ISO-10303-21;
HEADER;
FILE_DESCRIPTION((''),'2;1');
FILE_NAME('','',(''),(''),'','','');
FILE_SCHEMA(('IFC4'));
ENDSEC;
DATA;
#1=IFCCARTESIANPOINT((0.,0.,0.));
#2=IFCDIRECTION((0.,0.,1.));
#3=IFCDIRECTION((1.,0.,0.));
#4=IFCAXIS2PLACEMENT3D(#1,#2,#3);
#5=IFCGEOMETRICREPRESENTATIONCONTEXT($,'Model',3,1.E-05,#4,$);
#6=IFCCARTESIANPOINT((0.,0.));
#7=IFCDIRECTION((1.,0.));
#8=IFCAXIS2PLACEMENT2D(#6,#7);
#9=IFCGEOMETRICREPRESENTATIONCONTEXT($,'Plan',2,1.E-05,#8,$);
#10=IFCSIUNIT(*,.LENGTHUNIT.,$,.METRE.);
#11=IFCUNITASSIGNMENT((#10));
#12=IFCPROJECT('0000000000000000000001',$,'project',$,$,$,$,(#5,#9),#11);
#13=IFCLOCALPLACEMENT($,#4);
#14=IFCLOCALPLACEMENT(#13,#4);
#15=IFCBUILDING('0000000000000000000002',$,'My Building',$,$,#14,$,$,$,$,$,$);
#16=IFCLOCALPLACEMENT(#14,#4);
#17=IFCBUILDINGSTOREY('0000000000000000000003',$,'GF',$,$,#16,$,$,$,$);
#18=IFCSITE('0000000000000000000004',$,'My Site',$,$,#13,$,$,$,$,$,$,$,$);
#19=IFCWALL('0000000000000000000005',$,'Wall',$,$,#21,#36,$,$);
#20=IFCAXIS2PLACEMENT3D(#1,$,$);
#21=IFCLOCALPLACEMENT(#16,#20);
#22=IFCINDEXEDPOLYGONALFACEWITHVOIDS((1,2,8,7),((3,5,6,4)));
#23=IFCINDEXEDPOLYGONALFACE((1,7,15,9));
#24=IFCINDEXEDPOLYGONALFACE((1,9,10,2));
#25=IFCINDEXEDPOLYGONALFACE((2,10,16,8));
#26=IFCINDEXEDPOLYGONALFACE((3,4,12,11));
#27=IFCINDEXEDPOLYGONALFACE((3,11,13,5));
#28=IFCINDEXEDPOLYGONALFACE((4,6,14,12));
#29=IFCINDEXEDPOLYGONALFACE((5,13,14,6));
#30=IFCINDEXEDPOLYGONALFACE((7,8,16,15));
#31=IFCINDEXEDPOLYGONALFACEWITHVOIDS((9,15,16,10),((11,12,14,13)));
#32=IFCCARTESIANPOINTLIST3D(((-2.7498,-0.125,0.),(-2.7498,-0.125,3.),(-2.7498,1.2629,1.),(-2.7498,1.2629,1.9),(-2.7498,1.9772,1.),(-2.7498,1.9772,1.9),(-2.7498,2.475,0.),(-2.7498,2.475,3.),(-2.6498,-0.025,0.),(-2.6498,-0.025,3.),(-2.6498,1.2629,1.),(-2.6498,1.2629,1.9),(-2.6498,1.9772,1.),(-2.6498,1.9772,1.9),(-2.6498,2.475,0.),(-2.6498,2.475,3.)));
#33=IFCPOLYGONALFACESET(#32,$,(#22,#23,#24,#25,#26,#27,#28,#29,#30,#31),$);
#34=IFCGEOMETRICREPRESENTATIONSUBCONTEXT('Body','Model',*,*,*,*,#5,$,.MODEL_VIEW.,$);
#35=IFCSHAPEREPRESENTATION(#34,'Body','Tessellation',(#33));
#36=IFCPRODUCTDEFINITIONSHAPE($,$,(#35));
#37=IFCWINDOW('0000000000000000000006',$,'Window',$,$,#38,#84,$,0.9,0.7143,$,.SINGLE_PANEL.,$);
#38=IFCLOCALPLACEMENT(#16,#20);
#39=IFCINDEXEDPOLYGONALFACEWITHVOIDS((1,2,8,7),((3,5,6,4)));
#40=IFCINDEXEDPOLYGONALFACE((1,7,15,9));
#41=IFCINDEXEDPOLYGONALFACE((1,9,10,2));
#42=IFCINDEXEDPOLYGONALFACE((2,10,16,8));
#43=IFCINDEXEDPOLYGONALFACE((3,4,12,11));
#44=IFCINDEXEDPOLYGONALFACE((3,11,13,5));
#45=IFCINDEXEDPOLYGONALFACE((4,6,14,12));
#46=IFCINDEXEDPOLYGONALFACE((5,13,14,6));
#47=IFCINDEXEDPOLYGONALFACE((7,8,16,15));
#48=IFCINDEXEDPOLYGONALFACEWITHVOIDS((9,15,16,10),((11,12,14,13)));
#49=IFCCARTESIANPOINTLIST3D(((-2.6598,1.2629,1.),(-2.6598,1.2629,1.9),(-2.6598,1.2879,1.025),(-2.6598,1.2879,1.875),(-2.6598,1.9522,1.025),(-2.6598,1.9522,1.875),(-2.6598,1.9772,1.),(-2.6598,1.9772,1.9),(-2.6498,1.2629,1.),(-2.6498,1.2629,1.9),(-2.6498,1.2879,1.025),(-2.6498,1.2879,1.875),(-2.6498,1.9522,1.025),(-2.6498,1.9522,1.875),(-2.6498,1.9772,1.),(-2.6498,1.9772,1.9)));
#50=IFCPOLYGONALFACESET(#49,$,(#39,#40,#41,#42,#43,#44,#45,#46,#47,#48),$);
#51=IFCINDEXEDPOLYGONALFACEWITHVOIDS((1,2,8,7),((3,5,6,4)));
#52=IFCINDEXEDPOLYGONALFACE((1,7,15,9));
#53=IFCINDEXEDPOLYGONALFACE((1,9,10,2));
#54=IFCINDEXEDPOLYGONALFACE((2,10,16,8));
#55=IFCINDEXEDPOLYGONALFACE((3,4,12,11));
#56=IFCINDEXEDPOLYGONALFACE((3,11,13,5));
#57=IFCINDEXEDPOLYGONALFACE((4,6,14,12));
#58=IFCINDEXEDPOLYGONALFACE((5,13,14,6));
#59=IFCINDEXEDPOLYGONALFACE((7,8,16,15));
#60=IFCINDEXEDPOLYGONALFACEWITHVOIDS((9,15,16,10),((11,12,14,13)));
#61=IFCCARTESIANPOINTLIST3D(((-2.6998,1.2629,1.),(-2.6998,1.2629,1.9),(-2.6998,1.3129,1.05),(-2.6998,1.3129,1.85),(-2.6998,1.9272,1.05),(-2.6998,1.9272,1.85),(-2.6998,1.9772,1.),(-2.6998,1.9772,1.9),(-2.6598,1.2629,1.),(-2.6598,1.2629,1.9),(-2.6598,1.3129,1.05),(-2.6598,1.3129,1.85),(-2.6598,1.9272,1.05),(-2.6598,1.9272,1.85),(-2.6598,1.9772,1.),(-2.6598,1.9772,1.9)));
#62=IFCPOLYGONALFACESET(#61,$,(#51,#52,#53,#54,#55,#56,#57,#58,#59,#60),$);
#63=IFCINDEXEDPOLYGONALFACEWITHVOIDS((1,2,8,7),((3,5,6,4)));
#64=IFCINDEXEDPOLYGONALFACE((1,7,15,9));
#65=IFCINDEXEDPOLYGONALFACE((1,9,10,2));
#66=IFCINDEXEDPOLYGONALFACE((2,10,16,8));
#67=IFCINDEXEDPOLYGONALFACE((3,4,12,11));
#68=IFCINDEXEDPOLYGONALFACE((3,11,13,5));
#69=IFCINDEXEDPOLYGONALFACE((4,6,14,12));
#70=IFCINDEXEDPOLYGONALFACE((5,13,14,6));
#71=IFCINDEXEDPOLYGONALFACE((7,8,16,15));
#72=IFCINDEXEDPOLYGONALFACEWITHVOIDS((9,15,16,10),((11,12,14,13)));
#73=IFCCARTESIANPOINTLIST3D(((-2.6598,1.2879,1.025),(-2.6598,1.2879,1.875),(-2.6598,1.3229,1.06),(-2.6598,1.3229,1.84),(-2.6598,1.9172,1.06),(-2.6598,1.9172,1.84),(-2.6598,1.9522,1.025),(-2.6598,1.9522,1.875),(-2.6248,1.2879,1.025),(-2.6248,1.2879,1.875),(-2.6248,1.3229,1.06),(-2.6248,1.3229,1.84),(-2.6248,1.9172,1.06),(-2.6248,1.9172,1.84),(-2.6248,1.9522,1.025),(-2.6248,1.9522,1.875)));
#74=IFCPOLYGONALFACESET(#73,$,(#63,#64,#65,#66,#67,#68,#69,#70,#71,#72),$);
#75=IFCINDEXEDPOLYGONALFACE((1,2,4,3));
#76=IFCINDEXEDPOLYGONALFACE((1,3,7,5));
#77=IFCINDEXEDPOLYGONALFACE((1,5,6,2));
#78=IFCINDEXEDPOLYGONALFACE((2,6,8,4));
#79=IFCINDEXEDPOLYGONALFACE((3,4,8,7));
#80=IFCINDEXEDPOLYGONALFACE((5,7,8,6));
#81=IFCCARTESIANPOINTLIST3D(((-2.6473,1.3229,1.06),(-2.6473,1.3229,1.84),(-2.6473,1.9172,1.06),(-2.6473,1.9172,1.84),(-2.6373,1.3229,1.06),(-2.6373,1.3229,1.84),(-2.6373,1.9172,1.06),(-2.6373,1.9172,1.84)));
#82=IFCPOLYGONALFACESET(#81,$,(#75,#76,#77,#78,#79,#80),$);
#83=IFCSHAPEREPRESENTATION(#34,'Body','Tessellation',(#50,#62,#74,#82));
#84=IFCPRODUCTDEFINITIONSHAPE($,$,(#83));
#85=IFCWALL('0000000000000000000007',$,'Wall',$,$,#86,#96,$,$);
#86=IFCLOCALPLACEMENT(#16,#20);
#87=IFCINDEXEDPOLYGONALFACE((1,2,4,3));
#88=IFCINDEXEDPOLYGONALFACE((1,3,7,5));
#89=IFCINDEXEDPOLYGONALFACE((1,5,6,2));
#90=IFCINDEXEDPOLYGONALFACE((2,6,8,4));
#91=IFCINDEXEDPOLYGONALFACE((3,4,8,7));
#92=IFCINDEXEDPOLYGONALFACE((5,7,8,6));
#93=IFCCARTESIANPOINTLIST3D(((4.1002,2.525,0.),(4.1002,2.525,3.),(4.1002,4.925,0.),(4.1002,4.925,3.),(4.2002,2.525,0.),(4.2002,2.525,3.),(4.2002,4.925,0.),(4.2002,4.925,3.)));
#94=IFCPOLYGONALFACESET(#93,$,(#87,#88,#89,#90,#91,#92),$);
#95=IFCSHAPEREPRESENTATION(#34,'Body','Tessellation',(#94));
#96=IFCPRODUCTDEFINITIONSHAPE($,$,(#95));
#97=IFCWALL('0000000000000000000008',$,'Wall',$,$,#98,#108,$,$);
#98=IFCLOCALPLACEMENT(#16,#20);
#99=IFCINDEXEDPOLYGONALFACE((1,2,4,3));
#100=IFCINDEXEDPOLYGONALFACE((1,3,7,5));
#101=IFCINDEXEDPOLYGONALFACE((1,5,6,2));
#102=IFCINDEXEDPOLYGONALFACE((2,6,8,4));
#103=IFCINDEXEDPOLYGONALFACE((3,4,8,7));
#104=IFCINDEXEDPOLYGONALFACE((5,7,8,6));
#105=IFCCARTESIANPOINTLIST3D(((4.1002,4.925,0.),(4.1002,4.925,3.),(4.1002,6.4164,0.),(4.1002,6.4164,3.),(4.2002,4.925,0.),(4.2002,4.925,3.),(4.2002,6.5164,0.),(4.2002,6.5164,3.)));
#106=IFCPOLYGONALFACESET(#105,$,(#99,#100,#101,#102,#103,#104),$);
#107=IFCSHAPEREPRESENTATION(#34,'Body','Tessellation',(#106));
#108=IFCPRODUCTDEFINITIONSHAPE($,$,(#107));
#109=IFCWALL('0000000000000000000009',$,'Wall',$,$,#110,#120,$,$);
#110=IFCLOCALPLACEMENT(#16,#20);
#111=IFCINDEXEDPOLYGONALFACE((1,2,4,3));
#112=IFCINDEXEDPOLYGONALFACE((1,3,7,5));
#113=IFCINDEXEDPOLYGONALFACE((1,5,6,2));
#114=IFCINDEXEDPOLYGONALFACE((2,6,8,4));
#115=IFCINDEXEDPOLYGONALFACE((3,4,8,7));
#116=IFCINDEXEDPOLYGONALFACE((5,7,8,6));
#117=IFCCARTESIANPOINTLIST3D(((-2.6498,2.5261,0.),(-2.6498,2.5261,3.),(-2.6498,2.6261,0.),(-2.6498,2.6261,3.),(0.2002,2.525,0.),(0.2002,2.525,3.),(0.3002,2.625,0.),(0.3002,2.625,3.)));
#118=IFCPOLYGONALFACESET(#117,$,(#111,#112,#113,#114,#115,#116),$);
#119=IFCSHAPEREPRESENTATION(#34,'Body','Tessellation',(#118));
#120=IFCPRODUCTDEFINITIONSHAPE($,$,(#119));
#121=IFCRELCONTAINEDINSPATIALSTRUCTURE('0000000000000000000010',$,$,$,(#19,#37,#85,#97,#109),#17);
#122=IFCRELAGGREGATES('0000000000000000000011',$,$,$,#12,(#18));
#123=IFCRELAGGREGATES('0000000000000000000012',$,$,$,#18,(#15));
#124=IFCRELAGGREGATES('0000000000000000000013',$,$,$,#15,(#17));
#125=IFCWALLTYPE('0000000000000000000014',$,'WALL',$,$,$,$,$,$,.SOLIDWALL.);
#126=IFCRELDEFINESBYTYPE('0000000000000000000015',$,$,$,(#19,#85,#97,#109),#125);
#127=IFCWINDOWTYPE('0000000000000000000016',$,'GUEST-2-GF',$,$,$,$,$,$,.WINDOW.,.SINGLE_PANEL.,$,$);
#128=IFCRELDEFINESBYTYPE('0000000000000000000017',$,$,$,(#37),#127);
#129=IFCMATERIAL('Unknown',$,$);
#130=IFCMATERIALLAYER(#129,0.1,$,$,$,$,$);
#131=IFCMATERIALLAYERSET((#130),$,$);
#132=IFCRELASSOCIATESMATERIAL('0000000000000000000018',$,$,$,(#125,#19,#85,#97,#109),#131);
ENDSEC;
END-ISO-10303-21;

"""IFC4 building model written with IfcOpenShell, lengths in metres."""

from ifc_helpers import new_model, entity, si_unit, frame, origin_with_axes, origin_2d_with_axis, place, context, subcontext, project, spatial, line, indexed_curve, outline, extrude, shape, source, transform, mapped, material, layer, layer_set, layer_usage, type_object, type_shapes, element, fill, save


model = new_model("IFC4")

# Units and contexts
model_context = context("Model", 3, precision=1e-05, world=origin_with_axes())
plan_context = context("Plan", 2, precision=1e-05, world=origin_2d_with_axis())
body_context_1 = subcontext(model_context, "Body", "Model", "MODEL_VIEW")
body_context_2 = subcontext(plan_context, "Body", "Plan", "PLAN_VIEW")
ifc_project = project(units=[si_unit("LENGTHUNIT", "METRE")], contexts=[model_context, plan_context])

# Site, building, storey
site_placement = place(None, origin_with_axes())
site = spatial("IfcSite", under=ifc_project, at=site_placement, Name="My Site")
building_placement = place(site_placement, origin_with_axes())
building = spatial("IfcBuilding", under=site, at=building_placement, Name="My Building")
storey_placement = place(building_placement, origin_with_axes())
storey = spatial("IfcBuildingStorey", under=building, at=storey_placement, Name="GF")

# Shared definitions
ifc_material_1 = material(Name="Unknown")

# Shared definitions
ifc_layer_1 = layer(ifc_material_1, 0.1)
ifc_layer_set_1 = layer_set([ifc_layer_1])
wall_type = type_object("IfcWallType", Name="WALL", PredefinedType="SOLIDWALL", material=ifc_layer_set_1)

# Wall, opening, window
ifc_layer_usage_1 = layer_usage(ifc_layer_set_1, "AXIS2", "POSITIVE", 0.0)
wall_1_placement = place(storey_placement, frame((-2.7498, 2.475, 0.0), z_axis=(0.0, 0.0, 1.0), x_axis=(0.0, -1.0, 0.0)))
wall_1 = element("IfcWall", 1, at=wall_1_placement, inside=storey, type_object=wall_type, material=ifc_layer_usage_1, Name="Wall", context=body_context_1, shape_type="SweptSolid", body=[
    extrude(outline(indexed_curve([(0.0, 0.0), (0.0, 0.1), (2.5, 0.1), (2.6, 0.0)], segments=[line(1, 2, 3, 4, 1)])), origin_with_axes(), (0.0, 0.0, 1.0), 3.0),
])
shared_shape_1 = source(origin_with_axes(), body_context_1, "Body", "SweptSolid", [
    extrude(outline(indexed_curve([(0.0, 0.0), (0.7143, 0.0), (0.7143, 0.9), (0.0, 0.9)], segments=[line(1, 2, 3, 4, 1)])), frame((0.0, -0.6, 0.0), z_axis=(0.0, -1.0, 0.0), x_axis=(1.0, 0.0, 0.0)), (0.0, 0.0, -1.0), 1.2),
])
opening_1_placement = place(wall_1_placement, frame((0.4978, 0.0, 1.0), z_axis=(0.0, 0.0, 1.0), x_axis=(1.0, 0.0, 0.0)))
opening_1 = element("IfcOpeningElement", 2, at=opening_1_placement, cuts=wall_1, PredefinedType="OPENING", context=body_context_1, shape_type="MappedRepresentation", body=[
    mapped(shared_shape_1, transform((0.0, 0.0, 0.0), x_axis=(1.0, 0.0, 0.0), y_axis=(0.0, 1.0, 0.0), z_axis=(0.0, 0.0, 1.0), scale=1.0)),
])
window_type_1 = type_object("IfcWindowType", Name="GUEST-2-GF", PartitioningType="SINGLE_PANEL", PredefinedType="WINDOW")
shared_shape_2 = source(origin_with_axes(), body_context_1, "Body", "SweptSolid", [
    extrude(outline(indexed_curve([(0.0, 0.0), (0.7143, 0.0), (0.7143, 0.9), (0.0, 0.9)], segments=[line(1, 2, 3, 4, 1)]), holes=[indexed_curve([(0.025, 0.025), (0.6893, 0.025), (0.6893, 0.875), (0.025, 0.875)], segments=[line(1, 2, 3, 4, 1)])]), frame((0.0, 0.09, 0.0), z_axis=(0.0, -1.0, 0.0), x_axis=(1.0, 0.0, 0.0)), (0.0, 0.0, -1.0), 0.01),
    extrude(outline(indexed_curve([(0.0, 0.0), (0.7143, 0.0), (0.7143, 0.9), (0.0, 0.9)], segments=[line(1, 2, 3, 4, 1)]), holes=[indexed_curve([(0.05, 0.05), (0.6643, 0.05), (0.6643, 0.85), (0.05, 0.85)], segments=[line(1, 2, 3, 4, 1)])]), frame((0.0, 0.05, 0.0), z_axis=(0.0, -1.0, 0.0), x_axis=(1.0, 0.0, 0.0)), (0.0, 0.0, -1.0), 0.04),
    extrude(outline(indexed_curve([(0.0, 0.0), (0.6643, 0.0), (0.6643, 0.85), (0.0, 0.85)], segments=[line(1, 2, 3, 4, 1)]), holes=[indexed_curve([(0.035, 0.035), (0.6293, 0.035), (0.6293, 0.815), (0.035, 0.815)], segments=[line(1, 2, 3, 4, 1)])]), frame((0.025, 0.09, 0.025), z_axis=(0.0, -1.0, 0.0), x_axis=(1.0, 0.0, 0.0)), (0.0, 0.0, -1.0), 0.035),
    extrude(outline(indexed_curve([(0.035, 0.035), (0.6293, 0.035), (0.6293, 0.815), (0.035, 0.815)], segments=[line(1, 2, 3, 4, 1)])), frame((0.025, 0.1025, 0.025), z_axis=(0.0, -1.0, 0.0), x_axis=(1.0, 0.0, 0.0)), (0.0, 0.0, -1.0), 0.01),
])
shared_shape_3 = source(origin_with_axes(), body_context_2, "Body", "Curve2D", [
    entity("IfcIndexedPolyCurve", entity("IfcCartesianPointList2D", [[0.05, 0.05], [0.6643, 0.05]])),
    entity("IfcIndexedPolyCurve", entity("IfcCartesianPointList2D", [[0.0, 0.1], [0.025, 0.1], [0.025, 0.09], [0.05, 0.09], [0.05, 0.05], [0.0, 0.05]]), [entity("IfcLineIndex", [1, 2, 3, 4, 5, 6, 1])]),
    entity("IfcIndexedPolyCurve", entity("IfcCartesianPointList2D", [[0.7143, 0.1], [0.6893, 0.1], [0.6893, 0.09], [0.6643, 0.09], [0.6643, 0.05], [0.7143, 0.05]]), [entity("IfcLineIndex", [1, 2, 3, 4, 5, 6, 1])]),
    entity("IfcIndexedPolyCurve", entity("IfcCartesianPointList2D", [[0.025, 0.09], [0.06, 0.09], [0.06, 0.125], [0.025, 0.125]]), [entity("IfcLineIndex", [1, 2, 3, 4, 1])]),
    entity("IfcIndexedPolyCurve", entity("IfcCartesianPointList2D", [[0.6893, 0.09], [0.6543, 0.09], [0.6543, 0.125], [0.6893, 0.125]]), [entity("IfcLineIndex", [1, 2, 3, 4, 1])]),
    entity("IfcIndexedPolyCurve", entity("IfcCartesianPointList2D", [[0.06, 0.09], [0.6543, 0.09]])),
    entity("IfcIndexedPolyCurve", entity("IfcCartesianPointList2D", [[0.06, 0.125], [0.6543, 0.125]])),
    entity("IfcIndexedPolyCurve", entity("IfcCartesianPointList2D", [[0.06, 0.1075], [0.6543, 0.1075]])),
])
type_shapes(window_type_1, [shared_shape_2, shared_shape_3])
window_1_placement = place(opening_1_placement, frame((0.0, 0.0, 0.0), z_axis=(0.0, 0.0, 1.0), x_axis=(1.0, 0.0, 0.0)))
window_1 = element("IfcWindow", 3, at=window_1_placement, inside=storey, type_object=window_type_1, Name="Window", OverallHeight=0.9, OverallWidth=0.7143, PartitioningType="SINGLE_PANEL", shapes=[
    shape(body_context_1, "Body", "MappedRepresentation", [mapped(shared_shape_2, transform((0.0, 0.0, 0.0), x_axis=(1.0, 0.0, 0.0), y_axis=(0.0, 1.0, 0.0), z_axis=(0.0, 0.0, 1.0), scale=1.0))]),
    shape(body_context_2, "Body", "MappedRepresentation", [mapped(shared_shape_3, transform((0.0, 0.0, 0.0), x_axis=(1.0, 0.0, 0.0), y_axis=(0.0, 1.0, 0.0), z_axis=(0.0, 0.0, 1.0), scale=1.0))]),
])
fill(opening_1, window_1)

# Walls
ifc_layer_usage_2 = layer_usage(ifc_layer_set_1, "AXIS2", "POSITIVE", 0.0)
wall_2_placement = place(storey_placement, frame((4.2002, 2.525, 0.0), z_axis=(0.0, 0.0, 1.0), x_axis=(0.0, 1.0, 0.0)))
element("IfcWall", 4, at=wall_2_placement, inside=storey, type_object=wall_type, material=ifc_layer_usage_2, Name="Wall", context=body_context_1, shape_type="SweptSolid", body=[
    extrude(outline(indexed_curve([(0.0, 0.0), (0.0, 0.1), (2.4, 0.1), (2.4, 0.0)], segments=[line(1, 2, 3, 4, 1)])), origin_with_axes(), (0.0, 0.0, 1.0), 3.0),
])
ifc_layer_usage_3 = layer_usage(ifc_layer_set_1, "AXIS2", "POSITIVE", 0.0)
wall_3_placement = place(storey_placement, frame((4.2002, 4.925, 0.0), z_axis=(0.0, 0.0, 1.0), x_axis=(0.0, 1.0, 0.0)))
element("IfcWall", 5, at=wall_3_placement, inside=storey, type_object=wall_type, material=ifc_layer_usage_3, Name="Wall", context=body_context_1, shape_type="SweptSolid", body=[
    extrude(outline(indexed_curve([(0.0, 0.0), (0.0, 0.1), (1.4914, 0.1), (1.5914, 0.0)], segments=[line(1, 2, 3, 4, 1)])), origin_with_axes(), (0.0, 0.0, 1.0), 3.0),
])
ifc_layer_usage_4 = layer_usage(ifc_layer_set_1, "AXIS2", "POSITIVE", 0.0)
wall_4_placement = place(storey_placement, frame((0.3002, 2.625, 0.0), z_axis=(0.0, 0.0, 1.0), x_axis=(-1.0, 0.000366, 0.0)))
element("IfcWall", 6, at=wall_4_placement, inside=storey, type_object=wall_type, material=ifc_layer_usage_4, Name="Wall", context=body_context_1, shape_type="SweptSolid", body=[
    extrude(outline(indexed_curve([(0.0, 0.0), (0.1, 0.1), (2.95, 0.1), (2.95, 0.0)], segments=[line(1, 2, 3, 4, 1)])), origin_with_axes(), (0.0, 0.0, 1.0), 3.0),
])

save(model, "model.ifc")
